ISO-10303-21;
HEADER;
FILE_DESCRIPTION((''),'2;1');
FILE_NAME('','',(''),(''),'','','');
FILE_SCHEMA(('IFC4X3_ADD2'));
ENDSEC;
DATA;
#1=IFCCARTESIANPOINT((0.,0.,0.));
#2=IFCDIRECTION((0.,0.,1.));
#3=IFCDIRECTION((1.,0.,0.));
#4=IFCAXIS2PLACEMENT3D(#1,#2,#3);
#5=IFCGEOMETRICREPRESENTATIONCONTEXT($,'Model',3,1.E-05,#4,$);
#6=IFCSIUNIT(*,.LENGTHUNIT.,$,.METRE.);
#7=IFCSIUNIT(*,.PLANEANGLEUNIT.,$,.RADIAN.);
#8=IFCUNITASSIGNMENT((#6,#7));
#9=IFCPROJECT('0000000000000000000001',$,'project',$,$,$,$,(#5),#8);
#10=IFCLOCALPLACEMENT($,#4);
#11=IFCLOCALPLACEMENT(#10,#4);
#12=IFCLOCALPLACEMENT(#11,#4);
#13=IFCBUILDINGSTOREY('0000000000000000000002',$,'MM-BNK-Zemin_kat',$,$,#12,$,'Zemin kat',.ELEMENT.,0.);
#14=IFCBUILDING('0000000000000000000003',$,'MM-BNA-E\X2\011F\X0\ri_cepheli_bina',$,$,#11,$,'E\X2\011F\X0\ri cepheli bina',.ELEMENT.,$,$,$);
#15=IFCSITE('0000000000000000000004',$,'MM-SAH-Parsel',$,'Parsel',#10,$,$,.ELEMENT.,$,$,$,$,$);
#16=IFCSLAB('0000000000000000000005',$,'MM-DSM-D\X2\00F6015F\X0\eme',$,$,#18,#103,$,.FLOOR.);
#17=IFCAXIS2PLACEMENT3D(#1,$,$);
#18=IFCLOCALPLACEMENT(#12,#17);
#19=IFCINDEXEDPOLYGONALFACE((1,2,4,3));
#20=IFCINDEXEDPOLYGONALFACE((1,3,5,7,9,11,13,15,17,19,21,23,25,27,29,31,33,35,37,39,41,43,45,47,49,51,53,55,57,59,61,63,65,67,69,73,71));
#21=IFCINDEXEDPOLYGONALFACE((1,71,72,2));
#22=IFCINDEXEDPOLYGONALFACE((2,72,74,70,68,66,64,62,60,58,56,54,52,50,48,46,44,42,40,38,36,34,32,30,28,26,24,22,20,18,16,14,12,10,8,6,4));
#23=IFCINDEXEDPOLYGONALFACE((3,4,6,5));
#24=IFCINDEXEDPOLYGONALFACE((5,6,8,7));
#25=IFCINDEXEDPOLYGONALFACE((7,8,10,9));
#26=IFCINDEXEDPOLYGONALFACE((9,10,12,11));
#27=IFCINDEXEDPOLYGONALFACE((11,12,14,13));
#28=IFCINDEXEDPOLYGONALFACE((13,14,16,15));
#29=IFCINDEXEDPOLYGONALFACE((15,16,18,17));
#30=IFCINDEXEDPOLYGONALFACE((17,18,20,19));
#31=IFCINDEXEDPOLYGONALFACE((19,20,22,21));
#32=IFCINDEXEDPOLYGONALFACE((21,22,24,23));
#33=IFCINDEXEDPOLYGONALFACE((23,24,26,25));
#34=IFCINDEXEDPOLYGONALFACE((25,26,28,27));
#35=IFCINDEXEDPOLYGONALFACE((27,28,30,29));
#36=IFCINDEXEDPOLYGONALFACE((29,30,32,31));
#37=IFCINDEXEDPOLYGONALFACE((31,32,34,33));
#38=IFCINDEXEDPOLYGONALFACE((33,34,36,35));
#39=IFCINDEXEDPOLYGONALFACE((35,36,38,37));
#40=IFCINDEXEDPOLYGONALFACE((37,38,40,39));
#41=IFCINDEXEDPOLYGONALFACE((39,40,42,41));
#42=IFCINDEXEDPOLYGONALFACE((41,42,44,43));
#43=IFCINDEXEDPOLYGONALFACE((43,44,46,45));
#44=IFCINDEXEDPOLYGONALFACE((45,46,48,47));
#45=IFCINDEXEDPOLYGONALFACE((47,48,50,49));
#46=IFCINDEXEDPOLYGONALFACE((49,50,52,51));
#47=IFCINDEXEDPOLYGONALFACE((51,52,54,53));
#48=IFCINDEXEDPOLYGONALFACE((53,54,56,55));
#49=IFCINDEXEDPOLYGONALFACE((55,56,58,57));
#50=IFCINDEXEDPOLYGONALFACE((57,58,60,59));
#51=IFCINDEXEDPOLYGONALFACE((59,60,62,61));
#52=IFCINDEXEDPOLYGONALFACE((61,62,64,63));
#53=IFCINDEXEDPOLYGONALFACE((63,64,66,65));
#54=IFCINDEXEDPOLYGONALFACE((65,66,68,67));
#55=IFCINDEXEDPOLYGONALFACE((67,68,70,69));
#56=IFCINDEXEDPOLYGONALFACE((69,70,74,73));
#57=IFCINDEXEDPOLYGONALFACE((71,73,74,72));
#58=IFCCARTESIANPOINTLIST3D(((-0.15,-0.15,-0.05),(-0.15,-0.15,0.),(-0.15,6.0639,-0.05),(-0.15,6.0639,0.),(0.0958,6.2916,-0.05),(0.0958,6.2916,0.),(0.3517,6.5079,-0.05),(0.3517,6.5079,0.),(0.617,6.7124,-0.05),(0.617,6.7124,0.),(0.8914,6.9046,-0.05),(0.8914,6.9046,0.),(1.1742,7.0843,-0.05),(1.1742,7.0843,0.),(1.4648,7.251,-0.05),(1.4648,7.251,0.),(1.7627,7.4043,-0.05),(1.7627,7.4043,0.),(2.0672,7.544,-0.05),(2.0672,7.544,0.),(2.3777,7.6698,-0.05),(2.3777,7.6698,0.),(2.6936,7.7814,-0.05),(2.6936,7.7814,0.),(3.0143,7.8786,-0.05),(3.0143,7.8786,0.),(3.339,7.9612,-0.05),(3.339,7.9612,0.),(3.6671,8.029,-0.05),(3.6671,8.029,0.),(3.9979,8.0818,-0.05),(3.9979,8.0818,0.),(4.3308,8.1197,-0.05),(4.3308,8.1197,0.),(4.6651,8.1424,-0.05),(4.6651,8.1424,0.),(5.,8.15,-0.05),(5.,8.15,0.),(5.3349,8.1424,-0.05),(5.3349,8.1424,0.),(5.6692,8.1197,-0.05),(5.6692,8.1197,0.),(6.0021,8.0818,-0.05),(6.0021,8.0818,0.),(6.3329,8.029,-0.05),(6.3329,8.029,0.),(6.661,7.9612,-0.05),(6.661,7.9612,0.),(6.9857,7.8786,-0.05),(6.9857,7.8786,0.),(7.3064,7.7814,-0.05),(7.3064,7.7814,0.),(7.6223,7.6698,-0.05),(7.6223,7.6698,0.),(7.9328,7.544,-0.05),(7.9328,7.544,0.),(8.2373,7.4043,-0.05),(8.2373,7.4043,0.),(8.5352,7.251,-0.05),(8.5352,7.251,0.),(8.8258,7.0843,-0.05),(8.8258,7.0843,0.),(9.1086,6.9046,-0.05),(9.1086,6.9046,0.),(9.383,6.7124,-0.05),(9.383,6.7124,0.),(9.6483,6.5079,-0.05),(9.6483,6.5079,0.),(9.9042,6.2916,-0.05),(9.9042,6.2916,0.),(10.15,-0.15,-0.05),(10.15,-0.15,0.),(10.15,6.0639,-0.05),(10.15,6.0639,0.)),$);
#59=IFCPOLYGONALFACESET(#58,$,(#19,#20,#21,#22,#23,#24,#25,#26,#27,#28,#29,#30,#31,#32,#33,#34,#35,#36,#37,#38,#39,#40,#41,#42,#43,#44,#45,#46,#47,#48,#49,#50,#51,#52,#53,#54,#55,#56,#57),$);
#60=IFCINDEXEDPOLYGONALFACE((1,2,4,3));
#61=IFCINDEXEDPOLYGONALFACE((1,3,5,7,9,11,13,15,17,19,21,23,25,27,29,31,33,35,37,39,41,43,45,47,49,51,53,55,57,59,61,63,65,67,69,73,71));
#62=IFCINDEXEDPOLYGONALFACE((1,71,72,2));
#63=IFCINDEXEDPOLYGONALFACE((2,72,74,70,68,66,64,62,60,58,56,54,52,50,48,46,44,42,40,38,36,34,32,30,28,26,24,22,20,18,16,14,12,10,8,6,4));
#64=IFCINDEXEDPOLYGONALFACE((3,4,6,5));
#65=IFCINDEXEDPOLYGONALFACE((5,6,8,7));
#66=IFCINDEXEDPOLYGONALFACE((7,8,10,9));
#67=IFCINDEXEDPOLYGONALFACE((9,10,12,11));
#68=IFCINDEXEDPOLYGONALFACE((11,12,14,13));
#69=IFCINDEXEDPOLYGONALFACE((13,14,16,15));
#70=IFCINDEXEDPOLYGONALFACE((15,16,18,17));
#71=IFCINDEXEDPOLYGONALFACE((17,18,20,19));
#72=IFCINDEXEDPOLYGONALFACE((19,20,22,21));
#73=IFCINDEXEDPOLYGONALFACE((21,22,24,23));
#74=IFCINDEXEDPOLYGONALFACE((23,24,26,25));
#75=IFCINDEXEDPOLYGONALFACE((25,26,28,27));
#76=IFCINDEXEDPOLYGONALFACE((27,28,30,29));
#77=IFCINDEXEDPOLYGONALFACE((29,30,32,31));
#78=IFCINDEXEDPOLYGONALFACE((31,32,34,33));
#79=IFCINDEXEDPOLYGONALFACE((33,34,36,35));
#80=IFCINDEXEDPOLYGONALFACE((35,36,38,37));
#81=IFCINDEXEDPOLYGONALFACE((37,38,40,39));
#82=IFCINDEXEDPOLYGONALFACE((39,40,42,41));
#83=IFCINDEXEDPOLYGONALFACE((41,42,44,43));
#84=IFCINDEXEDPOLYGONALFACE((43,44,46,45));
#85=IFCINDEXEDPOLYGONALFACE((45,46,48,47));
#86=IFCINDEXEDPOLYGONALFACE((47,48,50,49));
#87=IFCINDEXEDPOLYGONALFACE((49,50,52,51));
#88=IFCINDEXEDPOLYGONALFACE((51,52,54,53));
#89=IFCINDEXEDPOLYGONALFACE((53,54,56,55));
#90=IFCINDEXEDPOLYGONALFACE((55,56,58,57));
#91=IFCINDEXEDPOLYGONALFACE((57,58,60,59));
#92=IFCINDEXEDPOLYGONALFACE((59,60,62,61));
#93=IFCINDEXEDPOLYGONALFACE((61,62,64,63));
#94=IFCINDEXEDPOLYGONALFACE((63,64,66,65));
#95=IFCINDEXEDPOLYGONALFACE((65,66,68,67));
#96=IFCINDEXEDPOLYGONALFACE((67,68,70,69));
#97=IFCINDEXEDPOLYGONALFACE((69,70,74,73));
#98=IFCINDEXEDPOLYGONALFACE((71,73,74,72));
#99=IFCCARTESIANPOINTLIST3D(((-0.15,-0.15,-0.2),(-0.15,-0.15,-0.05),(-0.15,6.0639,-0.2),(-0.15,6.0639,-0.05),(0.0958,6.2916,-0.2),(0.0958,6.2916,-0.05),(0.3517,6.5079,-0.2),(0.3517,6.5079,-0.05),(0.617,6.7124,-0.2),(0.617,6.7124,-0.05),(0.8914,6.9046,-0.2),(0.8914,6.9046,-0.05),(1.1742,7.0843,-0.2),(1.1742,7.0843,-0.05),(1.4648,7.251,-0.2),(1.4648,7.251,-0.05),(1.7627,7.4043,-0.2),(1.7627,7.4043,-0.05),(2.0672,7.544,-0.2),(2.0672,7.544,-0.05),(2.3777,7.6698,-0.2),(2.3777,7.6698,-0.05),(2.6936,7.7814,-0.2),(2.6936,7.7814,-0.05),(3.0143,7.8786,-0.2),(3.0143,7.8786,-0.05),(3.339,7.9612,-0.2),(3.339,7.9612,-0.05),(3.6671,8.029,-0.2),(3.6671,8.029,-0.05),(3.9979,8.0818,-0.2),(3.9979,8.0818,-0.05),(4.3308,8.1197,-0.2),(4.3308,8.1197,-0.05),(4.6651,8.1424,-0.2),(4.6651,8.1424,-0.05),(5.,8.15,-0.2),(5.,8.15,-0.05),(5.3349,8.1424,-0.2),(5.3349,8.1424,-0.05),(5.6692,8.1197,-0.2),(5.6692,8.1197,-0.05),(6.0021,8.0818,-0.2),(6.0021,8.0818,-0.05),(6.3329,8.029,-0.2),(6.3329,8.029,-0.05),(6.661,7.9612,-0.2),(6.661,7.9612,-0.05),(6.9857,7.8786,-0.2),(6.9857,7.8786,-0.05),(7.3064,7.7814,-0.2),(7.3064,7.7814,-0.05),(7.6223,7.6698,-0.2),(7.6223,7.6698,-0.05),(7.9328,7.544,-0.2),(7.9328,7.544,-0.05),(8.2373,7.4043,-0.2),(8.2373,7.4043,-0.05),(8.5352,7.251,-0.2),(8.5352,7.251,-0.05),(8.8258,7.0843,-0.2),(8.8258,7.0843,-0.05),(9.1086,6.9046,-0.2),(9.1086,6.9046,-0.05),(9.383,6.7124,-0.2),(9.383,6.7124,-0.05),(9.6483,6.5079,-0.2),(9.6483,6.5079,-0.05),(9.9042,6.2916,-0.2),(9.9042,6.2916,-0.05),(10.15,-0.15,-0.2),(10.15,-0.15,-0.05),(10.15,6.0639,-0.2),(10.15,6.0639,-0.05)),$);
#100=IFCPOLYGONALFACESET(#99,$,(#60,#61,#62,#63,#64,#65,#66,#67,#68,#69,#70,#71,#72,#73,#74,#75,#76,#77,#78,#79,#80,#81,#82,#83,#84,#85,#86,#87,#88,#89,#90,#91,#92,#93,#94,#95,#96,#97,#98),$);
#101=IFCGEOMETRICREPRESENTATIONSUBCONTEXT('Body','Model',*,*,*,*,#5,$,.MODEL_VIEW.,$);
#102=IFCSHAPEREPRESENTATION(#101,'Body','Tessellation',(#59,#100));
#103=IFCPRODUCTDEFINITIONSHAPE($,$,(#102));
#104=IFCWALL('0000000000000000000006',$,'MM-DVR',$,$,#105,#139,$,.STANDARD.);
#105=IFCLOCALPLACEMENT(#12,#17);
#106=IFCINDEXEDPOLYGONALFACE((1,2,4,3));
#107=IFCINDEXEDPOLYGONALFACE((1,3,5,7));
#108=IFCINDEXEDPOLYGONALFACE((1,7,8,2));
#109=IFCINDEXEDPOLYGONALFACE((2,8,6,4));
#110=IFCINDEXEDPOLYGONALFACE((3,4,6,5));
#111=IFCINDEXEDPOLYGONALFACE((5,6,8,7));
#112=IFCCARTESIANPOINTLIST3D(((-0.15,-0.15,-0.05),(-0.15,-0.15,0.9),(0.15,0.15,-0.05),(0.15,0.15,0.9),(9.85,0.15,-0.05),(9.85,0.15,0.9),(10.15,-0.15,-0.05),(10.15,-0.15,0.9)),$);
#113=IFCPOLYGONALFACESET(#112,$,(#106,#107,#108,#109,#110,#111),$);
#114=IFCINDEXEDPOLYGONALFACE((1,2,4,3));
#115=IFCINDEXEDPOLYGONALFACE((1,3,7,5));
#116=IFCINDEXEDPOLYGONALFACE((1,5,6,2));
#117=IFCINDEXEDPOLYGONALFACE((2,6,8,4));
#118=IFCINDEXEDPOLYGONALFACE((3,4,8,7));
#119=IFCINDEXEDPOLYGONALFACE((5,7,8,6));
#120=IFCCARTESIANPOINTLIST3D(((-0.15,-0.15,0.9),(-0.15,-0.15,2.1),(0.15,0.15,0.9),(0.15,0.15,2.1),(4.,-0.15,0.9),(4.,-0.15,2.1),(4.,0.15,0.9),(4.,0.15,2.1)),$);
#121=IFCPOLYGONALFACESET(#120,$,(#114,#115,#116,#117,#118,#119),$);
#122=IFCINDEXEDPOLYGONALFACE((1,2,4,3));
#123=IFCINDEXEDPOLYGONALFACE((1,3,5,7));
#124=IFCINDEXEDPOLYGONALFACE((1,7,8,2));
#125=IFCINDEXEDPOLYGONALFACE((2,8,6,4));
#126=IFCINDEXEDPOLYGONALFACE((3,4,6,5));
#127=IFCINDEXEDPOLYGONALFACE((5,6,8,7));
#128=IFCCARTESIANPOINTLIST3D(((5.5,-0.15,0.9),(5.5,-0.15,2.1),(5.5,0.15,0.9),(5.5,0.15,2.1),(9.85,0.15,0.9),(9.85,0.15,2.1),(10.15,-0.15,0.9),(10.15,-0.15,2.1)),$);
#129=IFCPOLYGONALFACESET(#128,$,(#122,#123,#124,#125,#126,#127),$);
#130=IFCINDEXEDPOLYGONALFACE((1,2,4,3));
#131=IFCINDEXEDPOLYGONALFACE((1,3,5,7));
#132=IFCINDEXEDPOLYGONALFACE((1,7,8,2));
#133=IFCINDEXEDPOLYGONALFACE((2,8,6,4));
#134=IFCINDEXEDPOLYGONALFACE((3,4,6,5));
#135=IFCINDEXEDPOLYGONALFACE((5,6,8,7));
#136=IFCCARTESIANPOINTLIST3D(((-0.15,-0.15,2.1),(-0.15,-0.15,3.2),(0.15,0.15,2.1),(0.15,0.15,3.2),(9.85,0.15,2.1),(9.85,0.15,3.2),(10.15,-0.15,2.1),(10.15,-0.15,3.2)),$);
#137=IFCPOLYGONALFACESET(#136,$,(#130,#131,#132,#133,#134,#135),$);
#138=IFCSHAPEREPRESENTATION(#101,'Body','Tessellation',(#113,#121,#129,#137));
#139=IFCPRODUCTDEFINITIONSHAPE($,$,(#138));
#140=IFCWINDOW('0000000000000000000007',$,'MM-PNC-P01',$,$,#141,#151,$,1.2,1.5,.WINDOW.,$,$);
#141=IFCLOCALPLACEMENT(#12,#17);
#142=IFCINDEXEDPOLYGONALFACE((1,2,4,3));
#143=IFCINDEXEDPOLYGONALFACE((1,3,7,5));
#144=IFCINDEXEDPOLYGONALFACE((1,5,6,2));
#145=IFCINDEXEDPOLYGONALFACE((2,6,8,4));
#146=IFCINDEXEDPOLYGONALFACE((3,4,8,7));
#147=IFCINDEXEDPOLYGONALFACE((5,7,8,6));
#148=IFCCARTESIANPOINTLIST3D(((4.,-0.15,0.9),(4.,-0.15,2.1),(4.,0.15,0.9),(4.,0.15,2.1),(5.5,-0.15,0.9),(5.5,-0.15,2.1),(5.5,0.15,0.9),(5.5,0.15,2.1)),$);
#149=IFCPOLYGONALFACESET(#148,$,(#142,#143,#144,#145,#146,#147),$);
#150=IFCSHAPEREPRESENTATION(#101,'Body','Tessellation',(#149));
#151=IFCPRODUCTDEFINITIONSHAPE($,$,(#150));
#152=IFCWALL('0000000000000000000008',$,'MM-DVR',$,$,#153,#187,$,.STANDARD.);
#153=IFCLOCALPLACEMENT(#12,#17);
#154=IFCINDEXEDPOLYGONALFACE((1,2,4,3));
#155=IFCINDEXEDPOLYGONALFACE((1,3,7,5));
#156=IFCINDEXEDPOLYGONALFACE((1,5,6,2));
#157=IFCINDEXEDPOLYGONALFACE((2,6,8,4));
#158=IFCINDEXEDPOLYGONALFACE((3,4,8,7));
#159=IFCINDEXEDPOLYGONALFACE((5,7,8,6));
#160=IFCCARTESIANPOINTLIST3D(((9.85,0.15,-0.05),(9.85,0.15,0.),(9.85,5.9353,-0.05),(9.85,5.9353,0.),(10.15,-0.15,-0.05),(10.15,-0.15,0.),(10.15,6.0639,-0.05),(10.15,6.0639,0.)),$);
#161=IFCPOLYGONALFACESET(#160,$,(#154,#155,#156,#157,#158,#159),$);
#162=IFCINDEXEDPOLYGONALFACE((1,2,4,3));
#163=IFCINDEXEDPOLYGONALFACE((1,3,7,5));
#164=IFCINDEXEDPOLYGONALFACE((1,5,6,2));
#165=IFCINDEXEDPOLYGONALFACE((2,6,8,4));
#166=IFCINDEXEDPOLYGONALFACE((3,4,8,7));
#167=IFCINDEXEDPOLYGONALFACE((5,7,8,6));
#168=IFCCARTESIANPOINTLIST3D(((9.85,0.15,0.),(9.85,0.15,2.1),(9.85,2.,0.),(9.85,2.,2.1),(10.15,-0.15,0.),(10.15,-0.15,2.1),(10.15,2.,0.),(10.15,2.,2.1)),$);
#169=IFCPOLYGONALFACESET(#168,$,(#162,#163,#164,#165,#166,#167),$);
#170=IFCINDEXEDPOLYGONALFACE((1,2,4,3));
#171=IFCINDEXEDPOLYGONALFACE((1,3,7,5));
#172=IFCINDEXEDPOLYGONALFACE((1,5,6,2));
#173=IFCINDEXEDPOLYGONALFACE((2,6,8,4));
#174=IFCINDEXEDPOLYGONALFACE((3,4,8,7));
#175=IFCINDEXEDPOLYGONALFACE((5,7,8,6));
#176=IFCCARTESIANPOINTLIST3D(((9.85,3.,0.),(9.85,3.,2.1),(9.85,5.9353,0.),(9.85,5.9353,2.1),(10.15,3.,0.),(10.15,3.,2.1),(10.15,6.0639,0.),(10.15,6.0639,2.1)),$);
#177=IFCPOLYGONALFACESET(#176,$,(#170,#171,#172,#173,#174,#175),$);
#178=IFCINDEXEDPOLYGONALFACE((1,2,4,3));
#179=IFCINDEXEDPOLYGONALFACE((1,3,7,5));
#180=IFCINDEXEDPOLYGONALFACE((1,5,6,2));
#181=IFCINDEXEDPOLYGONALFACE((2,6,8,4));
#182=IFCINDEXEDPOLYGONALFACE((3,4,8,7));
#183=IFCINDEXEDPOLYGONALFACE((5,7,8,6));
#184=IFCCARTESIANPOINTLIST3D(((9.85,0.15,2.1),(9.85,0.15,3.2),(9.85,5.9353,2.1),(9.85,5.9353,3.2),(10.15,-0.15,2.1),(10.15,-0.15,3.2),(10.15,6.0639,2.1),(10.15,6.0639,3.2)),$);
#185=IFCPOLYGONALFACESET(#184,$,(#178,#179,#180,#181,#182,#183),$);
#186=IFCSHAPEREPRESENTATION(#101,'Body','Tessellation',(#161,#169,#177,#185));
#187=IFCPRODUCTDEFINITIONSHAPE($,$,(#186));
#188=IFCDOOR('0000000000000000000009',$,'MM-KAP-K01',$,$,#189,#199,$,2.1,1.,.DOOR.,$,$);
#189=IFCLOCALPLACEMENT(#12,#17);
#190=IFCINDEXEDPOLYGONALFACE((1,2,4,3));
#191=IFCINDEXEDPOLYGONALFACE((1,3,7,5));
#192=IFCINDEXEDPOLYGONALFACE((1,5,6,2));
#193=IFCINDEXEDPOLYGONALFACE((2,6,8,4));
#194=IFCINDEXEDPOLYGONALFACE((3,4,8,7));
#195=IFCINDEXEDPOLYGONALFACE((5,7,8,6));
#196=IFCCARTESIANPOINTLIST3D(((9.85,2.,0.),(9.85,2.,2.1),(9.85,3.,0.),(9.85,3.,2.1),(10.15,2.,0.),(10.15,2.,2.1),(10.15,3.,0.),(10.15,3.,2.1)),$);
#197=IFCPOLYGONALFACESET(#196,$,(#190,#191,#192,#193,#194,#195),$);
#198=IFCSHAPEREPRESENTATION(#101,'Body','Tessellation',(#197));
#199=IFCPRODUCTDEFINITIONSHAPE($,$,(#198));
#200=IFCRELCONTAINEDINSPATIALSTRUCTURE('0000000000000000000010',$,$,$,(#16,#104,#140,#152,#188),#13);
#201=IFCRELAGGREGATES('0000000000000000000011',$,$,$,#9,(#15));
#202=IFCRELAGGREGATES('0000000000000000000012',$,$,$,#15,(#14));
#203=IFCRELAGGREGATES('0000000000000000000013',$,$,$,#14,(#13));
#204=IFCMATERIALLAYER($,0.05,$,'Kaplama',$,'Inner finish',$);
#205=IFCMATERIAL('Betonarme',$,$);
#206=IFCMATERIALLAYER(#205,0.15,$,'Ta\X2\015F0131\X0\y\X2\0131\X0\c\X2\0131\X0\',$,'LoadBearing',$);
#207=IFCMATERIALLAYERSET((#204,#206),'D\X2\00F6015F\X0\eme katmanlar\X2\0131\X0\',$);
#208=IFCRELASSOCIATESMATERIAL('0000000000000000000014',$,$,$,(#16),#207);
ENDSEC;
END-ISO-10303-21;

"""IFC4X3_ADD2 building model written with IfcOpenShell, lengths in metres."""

from ifc_helpers import new_model, si_unit, frame, origin, origin_with_axes, place, context, subcontext, project, spatial, polyline, line, arc, indexed_curve, outline, extrude, material, layer, layer_set, layer_usage, element, fill, save


model = new_model("IFC4X3_ADD2")

# Units and contexts
model_context = context("Model", 3, precision=1e-05, world=origin_with_axes())
body_context = subcontext(model_context, "Body", "Model", "MODEL_VIEW")
ifc_project = project(units=[si_unit("LENGTHUNIT", "METRE"), si_unit("PLANEANGLEUNIT", "RADIAN")], contexts=[model_context])

# Site, building, storey
site_placement = place(None, origin_with_axes())
site = spatial("IfcSite", under=ifc_project, at=site_placement, Name="MM-SAH-Parsel", ObjectType="Parsel", CompositionType="ELEMENT")
building_placement = place(site_placement, origin_with_axes())
building = spatial("IfcBuilding", under=site, at=building_placement, Name="MM-BNA-Eğri_cepheli_bina", LongName="Eğri cepheli bina", CompositionType="ELEMENT")
storey_placement = place(building_placement, origin_with_axes())
storey = spatial("IfcBuildingStorey", under=building, at=storey_placement, Name="MM-BNK-Zemin_kat", LongName="Zemin kat", CompositionType="ELEMENT", Elevation=0.0)

# Slab
ifc_layer_1 = layer(None, 0.05, Name="Kaplama", Category="Inner finish")
ifc_material = material(Name="Betonarme")
ifc_layer_2 = layer(ifc_material, 0.15, Name="Taşıyıcı", Category="LoadBearing")
ifc_layer_set = layer_set([ifc_layer_1, ifc_layer_2], Name="Döşeme katmanları")
ifc_layer_usage = layer_usage(ifc_layer_set, "AXIS3", "NEGATIVE", 0.0)
slab_placement = place(storey_placement, origin_with_axes())
element("IfcSlab", 1, at=slab_placement, inside=storey, material=ifc_layer_usage, Name="MM-DSM-Döşeme", PredefinedType="FLOOR", context=body_context, shape_type="SweptSolid", body=[
    extrude(outline(indexed_curve([(-0.15, -0.15), (10.15, -0.15), (10.15, 6.0639), (5.0, 8.15), (-0.15, 6.0639)], segments=[line(1, 2, 3), arc(3, 4, 5), line(5, 1)], self_intersect=False)), frame((0.0, 0.0, -0.05)), (0.0, 0.0, 1.0), 0.05),
    extrude(outline(indexed_curve([(-0.15, -0.15), (10.15, -0.15), (10.15, 6.0639), (5.0, 8.15), (-0.15, 6.0639)], segments=[line(1, 2, 3), arc(3, 4, 5), line(5, 1)], self_intersect=False)), frame((0.0, 0.0, -0.2)), (0.0, 0.0, 1.0), 0.15),
])

# Wall, opening, window
wall_1_placement = place(storey_placement, origin_with_axes())
wall_1 = element("IfcWall", 2, at=wall_1_placement, inside=storey, Name="MM-DVR", PredefinedType="STANDARD", context=body_context, shape_type="SweptSolid", body=[
    extrude(outline(polyline([(0.15, 0.15), (9.85, 0.15), (10.15, -0.15), (-0.15, -0.15), (0.15, 0.15)])), frame((0.0, 0.0, -0.05)), (0.0, 0.0, 1.0), 0.95),
    extrude(outline(polyline([(-0.15, -0.15), (4.0, -0.15), (4.0, 0.15), (0.15, 0.15), (-0.15, -0.15)])), frame((0.0, 0.0, 0.9)), (0.0, 0.0, 1.0), 1.2),
    extrude(outline(polyline([(5.5, -0.15), (10.15, -0.15), (9.85, 0.15), (5.5, 0.15), (5.5, -0.15)])), frame((0.0, 0.0, 0.9)), (0.0, 0.0, 1.0), 1.2),
    extrude(outline(polyline([(0.15, 0.15), (9.85, 0.15), (10.15, -0.15), (-0.15, -0.15), (0.15, 0.15)])), frame((0.0, 0.0, 2.1)), (0.0, 0.0, 1.0), 1.1),
])
opening_1_placement = place(storey_placement, origin_with_axes())
opening_1 = element("IfcOpeningElement", 3, at=opening_1_placement, cuts=wall_1, PredefinedType="OPENING", context=body_context, identifier="Reference", shape_type="SweptSolid", body=[
    extrude(outline(polyline([(4.0, 0.15), (5.5, 0.15), (5.5, -0.15), (4.0, -0.15), (4.0, 0.15)])), frame((0.0, 0.0, 0.9)), (0.0, 0.0, 1.0), 1.2),
])
window_1_placement = place(storey_placement, origin_with_axes())
window_1 = element("IfcWindow", 4, at=window_1_placement, inside=storey, Name="MM-PNC-P01", OverallHeight=1.2, OverallWidth=1.5, PredefinedType="WINDOW", context=body_context, shape_type="SweptSolid", body=[
    extrude(outline(polyline([(4.0, 0.15), (5.5, 0.15), (5.5, -0.15), (4.0, -0.15), (4.0, 0.15)])), frame((0.0, 0.0, 0.9)), (0.0, 0.0, 1.0), 1.2),
])
fill(opening_1, window_1)

# Wall, opening, door
wall_2_placement = place(storey_placement, origin_with_axes())
wall_2 = element("IfcWall", 5, at=wall_2_placement, inside=storey, Name="MM-DVR", PredefinedType="STANDARD", context=body_context, shape_type="SweptSolid", body=[
    extrude(outline(polyline([(9.85, 0.15), (9.85, 5.9353), (10.15, 6.0639), (10.15, -0.15), (9.85, 0.15)])), frame((0.0, 0.0, -0.05)), (0.0, 0.0, 1.0), 0.05),
    extrude(outline(polyline([(10.15, -0.15), (10.15, 2.0), (9.85, 2.0), (9.85, 0.15), (10.15, -0.15)])), origin(), (0.0, 0.0, 1.0), 2.1),
    extrude(outline(polyline([(10.15, 3.0), (10.15, 6.0639), (9.85, 5.9353), (9.85, 3.0), (10.15, 3.0)])), origin(), (0.0, 0.0, 1.0), 2.1),
    extrude(outline(polyline([(9.85, 0.15), (9.85, 5.9353), (10.15, 6.0639), (10.15, -0.15), (9.85, 0.15)])), frame((0.0, 0.0, 2.1)), (0.0, 0.0, 1.0), 1.1),
])
opening_2_placement = place(storey_placement, origin_with_axes())
opening_2 = element("IfcOpeningElement", 6, at=opening_2_placement, cuts=wall_2, PredefinedType="OPENING", context=body_context, identifier="Reference", shape_type="SweptSolid", body=[
    extrude(outline(polyline([(9.85, 2.0), (9.85, 3.0), (10.15, 3.0), (10.15, 2.0), (9.85, 2.0)])), origin(), (0.0, 0.0, 1.0), 2.1),
])
door_placement = place(storey_placement, origin_with_axes())
door = element("IfcDoor", 7, at=door_placement, inside=storey, Name="MM-KAP-K01", OverallHeight=2.1, OverallWidth=1.0, PredefinedType="DOOR", context=body_context, shape_type="SweptSolid", body=[
    extrude(outline(polyline([(9.85, 2.0), (9.85, 3.0), (10.15, 3.0), (10.15, 2.0), (9.85, 2.0)])), origin(), (0.0, 0.0, 1.0), 2.1),
])
fill(opening_2, door)

save(model, "model.ifc")
